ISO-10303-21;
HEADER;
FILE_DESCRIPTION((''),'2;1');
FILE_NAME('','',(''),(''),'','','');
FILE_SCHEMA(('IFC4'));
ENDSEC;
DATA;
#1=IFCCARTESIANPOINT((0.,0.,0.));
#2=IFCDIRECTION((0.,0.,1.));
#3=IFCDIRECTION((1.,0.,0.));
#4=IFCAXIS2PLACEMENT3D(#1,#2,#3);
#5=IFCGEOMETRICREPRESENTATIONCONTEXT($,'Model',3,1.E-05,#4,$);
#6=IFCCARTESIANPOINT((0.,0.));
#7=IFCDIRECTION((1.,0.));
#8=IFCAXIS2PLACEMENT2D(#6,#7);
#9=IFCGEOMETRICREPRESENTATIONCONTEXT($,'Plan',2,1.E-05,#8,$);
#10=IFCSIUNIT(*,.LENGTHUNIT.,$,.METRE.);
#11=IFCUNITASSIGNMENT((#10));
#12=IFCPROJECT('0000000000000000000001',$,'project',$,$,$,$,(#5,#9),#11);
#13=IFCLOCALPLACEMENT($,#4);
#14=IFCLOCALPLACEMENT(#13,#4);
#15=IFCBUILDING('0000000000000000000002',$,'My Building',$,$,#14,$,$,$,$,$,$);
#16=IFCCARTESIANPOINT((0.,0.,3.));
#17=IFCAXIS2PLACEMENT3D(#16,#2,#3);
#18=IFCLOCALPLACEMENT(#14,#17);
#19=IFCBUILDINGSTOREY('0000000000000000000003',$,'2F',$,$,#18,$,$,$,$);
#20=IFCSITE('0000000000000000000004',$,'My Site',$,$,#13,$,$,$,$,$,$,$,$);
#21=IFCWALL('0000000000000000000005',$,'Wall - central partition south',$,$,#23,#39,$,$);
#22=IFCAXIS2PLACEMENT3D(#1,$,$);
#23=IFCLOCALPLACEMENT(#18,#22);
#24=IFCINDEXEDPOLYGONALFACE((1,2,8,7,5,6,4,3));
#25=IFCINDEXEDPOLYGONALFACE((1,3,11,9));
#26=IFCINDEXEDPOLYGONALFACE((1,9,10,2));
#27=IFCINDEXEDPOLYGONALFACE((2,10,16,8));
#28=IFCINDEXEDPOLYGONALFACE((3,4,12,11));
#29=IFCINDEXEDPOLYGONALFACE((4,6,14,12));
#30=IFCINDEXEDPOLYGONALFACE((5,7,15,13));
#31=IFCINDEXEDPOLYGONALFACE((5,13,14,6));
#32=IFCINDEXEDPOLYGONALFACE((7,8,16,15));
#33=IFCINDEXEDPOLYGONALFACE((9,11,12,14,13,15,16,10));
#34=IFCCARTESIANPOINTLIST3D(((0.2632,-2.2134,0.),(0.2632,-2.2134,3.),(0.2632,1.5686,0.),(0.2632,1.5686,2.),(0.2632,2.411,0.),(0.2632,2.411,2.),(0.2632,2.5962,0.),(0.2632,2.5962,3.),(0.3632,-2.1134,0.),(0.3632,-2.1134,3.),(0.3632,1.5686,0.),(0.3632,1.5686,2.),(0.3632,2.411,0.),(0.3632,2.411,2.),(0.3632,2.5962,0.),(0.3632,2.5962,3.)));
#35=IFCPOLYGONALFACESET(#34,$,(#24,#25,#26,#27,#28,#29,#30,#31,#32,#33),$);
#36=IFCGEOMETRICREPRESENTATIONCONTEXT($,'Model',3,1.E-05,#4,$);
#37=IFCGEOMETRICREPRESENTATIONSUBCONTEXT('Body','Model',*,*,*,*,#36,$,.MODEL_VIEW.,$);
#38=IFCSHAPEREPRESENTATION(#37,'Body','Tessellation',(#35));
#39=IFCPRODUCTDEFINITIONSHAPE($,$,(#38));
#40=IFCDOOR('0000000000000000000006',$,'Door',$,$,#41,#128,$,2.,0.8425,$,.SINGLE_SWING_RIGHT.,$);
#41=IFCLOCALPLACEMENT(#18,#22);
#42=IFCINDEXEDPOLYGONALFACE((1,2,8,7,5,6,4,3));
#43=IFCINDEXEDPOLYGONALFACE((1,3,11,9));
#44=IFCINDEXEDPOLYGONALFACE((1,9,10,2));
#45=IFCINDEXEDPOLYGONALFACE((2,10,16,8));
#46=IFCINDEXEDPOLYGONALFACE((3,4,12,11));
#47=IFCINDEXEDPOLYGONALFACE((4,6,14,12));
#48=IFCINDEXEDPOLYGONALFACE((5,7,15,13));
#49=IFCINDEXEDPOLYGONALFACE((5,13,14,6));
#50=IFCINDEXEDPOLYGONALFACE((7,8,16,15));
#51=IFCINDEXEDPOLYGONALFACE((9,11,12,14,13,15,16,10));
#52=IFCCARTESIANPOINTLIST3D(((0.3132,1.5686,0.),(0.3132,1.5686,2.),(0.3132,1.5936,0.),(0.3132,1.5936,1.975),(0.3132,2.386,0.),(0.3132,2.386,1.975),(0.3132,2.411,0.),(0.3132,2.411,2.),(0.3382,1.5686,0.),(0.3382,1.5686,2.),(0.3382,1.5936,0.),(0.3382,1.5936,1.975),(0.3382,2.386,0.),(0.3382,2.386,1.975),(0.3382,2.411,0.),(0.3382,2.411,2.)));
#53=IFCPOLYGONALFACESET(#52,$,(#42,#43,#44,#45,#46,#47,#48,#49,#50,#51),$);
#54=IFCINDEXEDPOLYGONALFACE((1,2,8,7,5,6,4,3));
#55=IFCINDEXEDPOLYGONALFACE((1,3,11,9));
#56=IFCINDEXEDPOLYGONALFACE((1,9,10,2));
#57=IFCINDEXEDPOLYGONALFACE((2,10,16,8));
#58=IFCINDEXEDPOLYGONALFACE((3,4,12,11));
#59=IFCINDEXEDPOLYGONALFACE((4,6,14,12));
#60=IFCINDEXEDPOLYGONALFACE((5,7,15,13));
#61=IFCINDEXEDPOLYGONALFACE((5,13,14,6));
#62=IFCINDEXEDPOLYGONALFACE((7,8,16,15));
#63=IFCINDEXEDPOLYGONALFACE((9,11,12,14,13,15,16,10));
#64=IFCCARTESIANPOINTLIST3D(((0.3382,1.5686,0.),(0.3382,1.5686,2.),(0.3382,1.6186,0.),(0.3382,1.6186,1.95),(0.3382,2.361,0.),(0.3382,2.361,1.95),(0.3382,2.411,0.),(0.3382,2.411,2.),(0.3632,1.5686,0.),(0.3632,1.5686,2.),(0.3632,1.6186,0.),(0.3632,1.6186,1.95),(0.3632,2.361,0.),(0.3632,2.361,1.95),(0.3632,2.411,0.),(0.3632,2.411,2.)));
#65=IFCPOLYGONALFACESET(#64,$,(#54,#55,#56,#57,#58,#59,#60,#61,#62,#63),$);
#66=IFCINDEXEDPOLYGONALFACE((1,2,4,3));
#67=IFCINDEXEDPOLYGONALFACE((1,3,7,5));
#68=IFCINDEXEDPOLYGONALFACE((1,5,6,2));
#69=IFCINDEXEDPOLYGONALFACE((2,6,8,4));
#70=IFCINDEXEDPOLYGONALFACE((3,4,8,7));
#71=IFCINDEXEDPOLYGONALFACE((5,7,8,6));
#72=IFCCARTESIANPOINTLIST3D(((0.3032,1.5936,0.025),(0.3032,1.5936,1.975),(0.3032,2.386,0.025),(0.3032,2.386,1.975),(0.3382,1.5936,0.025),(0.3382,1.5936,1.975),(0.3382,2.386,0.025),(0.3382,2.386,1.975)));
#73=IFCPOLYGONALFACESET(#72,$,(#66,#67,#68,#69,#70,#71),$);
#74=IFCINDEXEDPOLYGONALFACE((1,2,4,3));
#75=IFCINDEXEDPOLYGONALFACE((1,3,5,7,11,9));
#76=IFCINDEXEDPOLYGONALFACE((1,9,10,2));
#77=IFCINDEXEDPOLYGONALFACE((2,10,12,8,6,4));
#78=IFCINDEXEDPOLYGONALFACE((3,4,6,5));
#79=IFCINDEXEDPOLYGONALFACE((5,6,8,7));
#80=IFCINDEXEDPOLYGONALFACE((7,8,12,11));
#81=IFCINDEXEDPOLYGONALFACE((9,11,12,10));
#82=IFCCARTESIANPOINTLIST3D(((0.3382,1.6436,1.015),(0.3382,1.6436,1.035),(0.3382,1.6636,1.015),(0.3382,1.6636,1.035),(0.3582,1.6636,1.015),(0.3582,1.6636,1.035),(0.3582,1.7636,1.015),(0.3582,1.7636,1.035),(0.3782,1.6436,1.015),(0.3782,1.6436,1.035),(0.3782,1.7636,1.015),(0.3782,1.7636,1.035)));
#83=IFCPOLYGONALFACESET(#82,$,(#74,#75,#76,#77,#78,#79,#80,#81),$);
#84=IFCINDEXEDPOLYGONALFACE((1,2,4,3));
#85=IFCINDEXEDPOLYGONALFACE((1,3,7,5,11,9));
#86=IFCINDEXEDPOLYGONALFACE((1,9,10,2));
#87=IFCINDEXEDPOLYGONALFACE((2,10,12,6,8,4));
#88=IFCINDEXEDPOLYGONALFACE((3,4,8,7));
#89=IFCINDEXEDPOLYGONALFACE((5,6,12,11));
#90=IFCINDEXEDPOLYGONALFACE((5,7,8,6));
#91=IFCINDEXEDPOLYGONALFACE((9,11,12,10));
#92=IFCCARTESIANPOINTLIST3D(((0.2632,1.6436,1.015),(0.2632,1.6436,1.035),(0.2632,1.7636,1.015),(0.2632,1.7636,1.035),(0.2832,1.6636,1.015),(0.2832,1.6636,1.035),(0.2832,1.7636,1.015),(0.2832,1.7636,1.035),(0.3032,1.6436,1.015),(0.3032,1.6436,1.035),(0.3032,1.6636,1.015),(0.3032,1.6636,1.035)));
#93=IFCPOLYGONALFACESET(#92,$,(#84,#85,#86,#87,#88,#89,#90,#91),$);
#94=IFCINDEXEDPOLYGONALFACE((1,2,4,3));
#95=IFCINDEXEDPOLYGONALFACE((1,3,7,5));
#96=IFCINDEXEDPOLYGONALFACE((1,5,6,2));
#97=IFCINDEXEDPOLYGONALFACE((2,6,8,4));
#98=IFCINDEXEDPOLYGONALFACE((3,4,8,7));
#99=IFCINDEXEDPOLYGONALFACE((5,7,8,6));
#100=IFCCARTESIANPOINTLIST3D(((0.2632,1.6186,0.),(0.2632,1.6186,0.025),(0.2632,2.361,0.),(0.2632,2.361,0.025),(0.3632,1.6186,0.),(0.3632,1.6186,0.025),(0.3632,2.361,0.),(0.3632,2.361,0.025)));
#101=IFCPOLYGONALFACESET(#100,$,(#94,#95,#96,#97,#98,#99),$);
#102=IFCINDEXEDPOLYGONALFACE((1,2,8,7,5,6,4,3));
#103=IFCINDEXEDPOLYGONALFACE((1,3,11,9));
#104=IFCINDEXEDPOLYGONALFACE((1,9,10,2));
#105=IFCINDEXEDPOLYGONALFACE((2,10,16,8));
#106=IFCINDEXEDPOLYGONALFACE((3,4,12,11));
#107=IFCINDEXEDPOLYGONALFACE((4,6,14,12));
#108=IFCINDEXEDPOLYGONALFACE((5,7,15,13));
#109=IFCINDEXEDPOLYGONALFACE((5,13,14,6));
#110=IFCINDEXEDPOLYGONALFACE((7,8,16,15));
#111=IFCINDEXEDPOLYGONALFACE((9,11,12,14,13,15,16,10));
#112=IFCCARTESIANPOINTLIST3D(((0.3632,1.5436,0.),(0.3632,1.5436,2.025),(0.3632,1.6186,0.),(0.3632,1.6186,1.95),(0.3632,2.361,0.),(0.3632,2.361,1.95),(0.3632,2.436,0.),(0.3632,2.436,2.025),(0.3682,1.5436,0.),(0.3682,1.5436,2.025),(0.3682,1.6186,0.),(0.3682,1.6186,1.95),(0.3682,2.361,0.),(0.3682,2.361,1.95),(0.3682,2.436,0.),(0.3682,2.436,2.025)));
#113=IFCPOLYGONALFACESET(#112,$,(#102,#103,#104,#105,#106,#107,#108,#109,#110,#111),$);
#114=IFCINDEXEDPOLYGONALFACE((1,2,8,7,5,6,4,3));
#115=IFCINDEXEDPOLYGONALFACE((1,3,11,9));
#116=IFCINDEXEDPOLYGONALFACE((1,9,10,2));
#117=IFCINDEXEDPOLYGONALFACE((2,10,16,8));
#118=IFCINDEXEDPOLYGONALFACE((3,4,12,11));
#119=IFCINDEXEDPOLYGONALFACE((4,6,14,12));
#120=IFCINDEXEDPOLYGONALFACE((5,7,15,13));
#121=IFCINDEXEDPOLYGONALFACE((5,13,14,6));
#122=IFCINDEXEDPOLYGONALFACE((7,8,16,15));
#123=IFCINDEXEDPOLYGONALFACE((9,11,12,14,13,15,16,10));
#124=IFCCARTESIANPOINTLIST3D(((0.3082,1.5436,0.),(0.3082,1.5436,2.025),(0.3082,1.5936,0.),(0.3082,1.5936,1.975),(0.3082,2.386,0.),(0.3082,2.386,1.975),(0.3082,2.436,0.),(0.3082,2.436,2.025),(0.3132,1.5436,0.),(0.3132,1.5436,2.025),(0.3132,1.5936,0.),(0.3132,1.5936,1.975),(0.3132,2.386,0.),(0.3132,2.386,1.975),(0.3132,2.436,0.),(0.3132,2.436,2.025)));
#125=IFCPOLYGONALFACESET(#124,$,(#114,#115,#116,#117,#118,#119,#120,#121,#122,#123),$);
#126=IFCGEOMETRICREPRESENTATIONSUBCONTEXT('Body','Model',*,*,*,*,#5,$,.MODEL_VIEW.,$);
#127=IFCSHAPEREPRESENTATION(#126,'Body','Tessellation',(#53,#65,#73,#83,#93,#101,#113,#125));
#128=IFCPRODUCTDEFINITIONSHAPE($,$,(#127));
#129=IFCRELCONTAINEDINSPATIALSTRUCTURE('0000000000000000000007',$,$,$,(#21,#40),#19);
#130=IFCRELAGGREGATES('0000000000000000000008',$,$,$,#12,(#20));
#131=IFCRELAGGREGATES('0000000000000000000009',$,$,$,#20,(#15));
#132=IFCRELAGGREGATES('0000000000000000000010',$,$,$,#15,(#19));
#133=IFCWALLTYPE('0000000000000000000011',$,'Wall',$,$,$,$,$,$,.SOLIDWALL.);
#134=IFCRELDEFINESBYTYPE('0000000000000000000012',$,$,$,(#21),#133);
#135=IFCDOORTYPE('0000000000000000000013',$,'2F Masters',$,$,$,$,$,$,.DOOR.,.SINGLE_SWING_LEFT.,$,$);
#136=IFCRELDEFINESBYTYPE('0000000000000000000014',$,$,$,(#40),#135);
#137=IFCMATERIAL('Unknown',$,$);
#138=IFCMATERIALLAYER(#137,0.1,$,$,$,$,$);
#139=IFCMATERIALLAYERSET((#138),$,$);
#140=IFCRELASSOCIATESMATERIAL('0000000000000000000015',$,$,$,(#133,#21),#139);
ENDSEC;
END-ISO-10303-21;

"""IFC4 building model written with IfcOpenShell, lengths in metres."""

from ifc_helpers import new_model, entity, si_unit, frame, origin_with_axes, origin_2d_with_axis, place, context, subcontext, project, spatial, line, indexed_curve, outline, extrude, shape, source, transform, mapped, material, layer, layer_set, layer_usage, type_object, type_shapes, element, fill, save


model = new_model("IFC4")

# Units and contexts
model_context_1 = context("Model", 3, precision=1e-05, world=origin_with_axes())
plan_context = context("Plan", 2, precision=1e-05, world=origin_2d_with_axis())
model_context_2 = context("Model", 3, precision=1e-05, world=origin_with_axes())
body_context_1 = subcontext(model_context_1, "Body", "Model", "MODEL_VIEW")
body_context_2 = subcontext(plan_context, "Body", "Plan", "PLAN_VIEW")
body_context_3 = subcontext(model_context_2, "Body", "Model", "MODEL_VIEW")
ifc_project = project(units=[si_unit("LENGTHUNIT", "METRE")], contexts=[model_context_1, plan_context])

# Site, building, storey
site_placement = place(None, origin_with_axes())
site = spatial("IfcSite", under=ifc_project, at=site_placement, Name="My Site")
building_placement = place(site_placement, origin_with_axes())
building = spatial("IfcBuilding", under=site, at=building_placement, Name="My Building")
storey_placement = place(building_placement, frame((0.0, 0.0, 3.0), z_axis=(0.0, 0.0, 1.0), x_axis=(1.0, 0.0, 0.0)))
storey = spatial("IfcBuildingStorey", under=building, at=storey_placement, Name="2F")

# Shared definitions
ifc_material = material(Name="Unknown")

# Shared definitions
ifc_layer_1 = layer(ifc_material, 0.1)
ifc_layer_set_1 = layer_set([ifc_layer_1])
wall_type = type_object("IfcWallType", Name="Wall", PredefinedType="SOLIDWALL", material=ifc_layer_set_1)

# Shared definitions
ifc_layer_usage_1 = layer_usage(ifc_layer_set_1, "AXIS2", "POSITIVE", 0.0)

# Wall, opening, door
wall_1_placement = place(storey_placement, frame((0.2632, 2.5962, 0.0), z_axis=(0.0, 0.0, 1.0), x_axis=(0.0, -1.0, 0.0)))
wall_1 = element("IfcWall", 1, at=wall_1_placement, inside=storey, type_object=wall_type, material=ifc_layer_usage_1, Name="Wall - central partition south", context=body_context_3, shape_type="SweptSolid", body=[
    extrude(outline(indexed_curve([(0.0, 0.1), (4.7096, 0.1), (4.8096, 0.0), (0.0, 0.0)], segments=[line(1, 2, 3, 4, 1)])), origin_with_axes(), (0.0, 0.0, 1.0), 3.0),
])
shared_shape_1 = source(origin_with_axes(), body_context_1, "Body", "SweptSolid", [
    extrude(outline(indexed_curve([(0.0, 0.0), (0.8425, 0.0), (0.8425, 2.0), (0.0, 2.0)], segments=[line(1, 2, 3, 4, 1)])), frame((0.0, -0.6, 0.0), z_axis=(0.0, -1.0, 0.0), x_axis=(1.0, 0.0, 0.0)), (0.0, 0.0, -1.0), 1.2),
])
opening_1_placement = place(wall_1_placement, frame((1.0277, 0.1, 0.0), z_axis=(0.0, 0.0, 1.0), x_axis=(-1.0, 0.0, 0.0)))
opening_1 = element("IfcOpeningElement", 2, at=opening_1_placement, cuts=wall_1, PredefinedType="OPENING", context=body_context_1, shape_type="MappedRepresentation", body=[
    mapped(shared_shape_1, transform((0.0, 0.0, 0.0), x_axis=(1.0, 0.0, 0.0), y_axis=(0.0, 1.0, 0.0), z_axis=(0.0, 0.0, 1.0), scale=1.0)),
])
door_type_1 = type_object("IfcDoorType", Name="2F Masters", OperationType="SINGLE_SWING_LEFT", PredefinedType="DOOR")
shared_shape_2 = source(origin_with_axes(), body_context_1, "Body", "SweptSolid", [
    extrude(outline(indexed_curve([(0.0, 0.0), (0.0, 2.0), (0.8425, 2.0), (0.8425, 0.0), (0.8175, 0.0), (0.8175, 1.975), (0.025, 1.975), (0.025, 0.0)], segments=[line(1, 2, 3, 4, 5, 6, 7, 8, 1)])), frame((0.0, 0.025, 0.0), z_axis=(0.0, -1.0, 0.0), x_axis=(1.0, 0.0, 0.0)), (0.0, 0.0, -1.0), 0.025),
    extrude(outline(indexed_curve([(0.0, 0.0), (0.0, 2.0), (0.8425, 2.0), (0.8425, 0.0), (0.7925, 0.0), (0.7925, 1.95), (0.05, 1.95), (0.05, 0.0)], segments=[line(1, 2, 3, 4, 5, 6, 7, 8, 1)])), frame((0.0, 0.0, 0.0), z_axis=(0.0, -1.0, 0.0), x_axis=(1.0, 0.0, 0.0)), (0.0, 0.0, -1.0), 0.025),
    extrude(outline(indexed_curve([(0.0, 0.0), (0.7925, 0.0), (0.7925, 0.035), (0.0, 0.035)], segments=[line(1, 2, 3, 4, 1)])), frame((0.025, 0.025, 0.025), z_axis=(0.0, 0.0, 1.0), x_axis=(1.0, 0.0, 0.0)), (0.0, 0.0, 1.0), 1.95),
    extrude(outline(indexed_curve([(0.0, 0.0), (0.0, -0.04), (0.12, -0.04), (0.12, -0.02), (0.02, -0.02), (0.02, 0.0)], segments=[line(1, 2, 3, 4, 5, 6, 1)])), frame((0.075, 0.025, 1.015), z_axis=(0.0, 0.0, 1.0), x_axis=(1.0, 0.0, 0.0)), (0.0, 0.0, 1.0), 0.02),
    extrude(outline(indexed_curve([(0.0, 0.0), (0.0, 0.04), (0.12, 0.04), (0.12, 0.02), (0.02, 0.02), (0.02, 0.0)], segments=[line(1, 2, 3, 4, 5, 6, 1)])), frame((0.075, 0.06, 1.015), z_axis=(0.0, 0.0, 1.0), x_axis=(1.0, 0.0, 0.0)), (0.0, 0.0, 1.0), 0.02),
    extrude(outline(indexed_curve([(0.0, 0.0), (0.7425, 0.0), (0.7425, 0.1), (0.0, 0.1)], segments=[line(1, 2, 3, 4, 1)])), frame((0.05, 0.0, 0.0), z_axis=(0.0, 0.0, 1.0), x_axis=(1.0, 0.0, 0.0)), (0.0, 0.0, 1.0), 0.025),
    extrude(outline(indexed_curve([(0.0, 0.0), (0.0, 2.025), (0.8925, 2.025), (0.8925, 0.0), (0.8175, 0.0), (0.8175, 1.95), (0.075, 1.95), (0.075, 0.0)], segments=[line(1, 2, 3, 4, 5, 6, 7, 8, 1)])), frame((-0.025, -0.005, 0.0), z_axis=(0.0, -1.0, 0.0), x_axis=(1.0, 0.0, 0.0)), (0.0, 0.0, -1.0), 0.005),
    extrude(outline(indexed_curve([(0.0, 0.0), (0.0, 2.025), (0.8925, 2.025), (0.8925, 0.0), (0.8425, 0.0), (0.8425, 1.975), (0.05, 1.975), (0.05, 0.0)], segments=[line(1, 2, 3, 4, 5, 6, 7, 8, 1)])), frame((-0.025, 0.05, 0.0), z_axis=(0.0, -1.0, 0.0), x_axis=(1.0, 0.0, 0.0)), (0.0, 0.0, -1.0), 0.005),
])
shared_shape_3 = source(origin_with_axes(), body_context_2, "Body", "Curve2D", [
    entity("IfcIndexedPolyCurve", entity("IfcCartesianPointList2D", [[0.0, 0.0], [0.0, 0.05], [0.025, 0.05], [0.025, 0.025], [0.05, 0.025], [0.05, 0.0]]), [entity("IfcLineIndex", [1, 2, 3, 4, 5, 6, 1])]),
    entity("IfcIndexedPolyCurve", entity("IfcCartesianPointList2D", [[0.8425, 0.0], [0.8425, 0.05], [0.8175, 0.05], [0.8175, 0.025], [0.7925, 0.025], [0.7925, 0.0]]), [entity("IfcLineIndex", [1, 2, 3, 4, 5, 6, 1])]),
    entity("IfcTrimmedCurve", entity("IfcEllipse", entity("IfcAxis2Placement2D", entity("IfcCartesianPoint", [0.7825, 0.05]), entity("IfcDirection", [1.0, 0.0])), 0.7575, 0.7925), [entity("IfcCartesianPoint", [0.7825, 0.8425])], [entity("IfcCartesianPoint", [0.025, 0.05])], True, "CARTESIAN"),
    entity("IfcIndexedPolyCurve", entity("IfcCartesianPointList2D", [[0.8175, 0.05], [0.7825, 0.05], [0.7825, 0.8425], [0.8175, 0.8425]]), [entity("IfcLineIndex", [1, 2, 3, 4, 1])]),
])
type_shapes(door_type_1, [shared_shape_2, shared_shape_3])
door_1_placement = place(opening_1_placement, frame((0.0, 0.0, 0.0), z_axis=(0.0, 0.0, 1.0), x_axis=(1.0, 0.0, 0.0)))
door_1 = element("IfcDoor", 3, at=door_1_placement, inside=storey, type_object=door_type_1, Name="Door", OperationType="SINGLE_SWING_RIGHT", OverallHeight=2.0, OverallWidth=0.8425, shapes=[
    shape(body_context_1, "Body", "MappedRepresentation", [mapped(shared_shape_2, transform((0.0, 0.0, 0.0), x_axis=(1.0, 0.0, 0.0), y_axis=(0.0, 1.0, 0.0), z_axis=(0.0, 0.0, 1.0), scale=1.0))]),
    shape(body_context_2, "Body", "MappedRepresentation", [mapped(shared_shape_3, transform((0.0, 0.0, 0.0), x_axis=(1.0, 0.0, 0.0), y_axis=(0.0, 1.0, 0.0), z_axis=(0.0, 0.0, 1.0), scale=1.0))]),
])
fill(opening_1, door_1)

save(model, "model.ifc")
